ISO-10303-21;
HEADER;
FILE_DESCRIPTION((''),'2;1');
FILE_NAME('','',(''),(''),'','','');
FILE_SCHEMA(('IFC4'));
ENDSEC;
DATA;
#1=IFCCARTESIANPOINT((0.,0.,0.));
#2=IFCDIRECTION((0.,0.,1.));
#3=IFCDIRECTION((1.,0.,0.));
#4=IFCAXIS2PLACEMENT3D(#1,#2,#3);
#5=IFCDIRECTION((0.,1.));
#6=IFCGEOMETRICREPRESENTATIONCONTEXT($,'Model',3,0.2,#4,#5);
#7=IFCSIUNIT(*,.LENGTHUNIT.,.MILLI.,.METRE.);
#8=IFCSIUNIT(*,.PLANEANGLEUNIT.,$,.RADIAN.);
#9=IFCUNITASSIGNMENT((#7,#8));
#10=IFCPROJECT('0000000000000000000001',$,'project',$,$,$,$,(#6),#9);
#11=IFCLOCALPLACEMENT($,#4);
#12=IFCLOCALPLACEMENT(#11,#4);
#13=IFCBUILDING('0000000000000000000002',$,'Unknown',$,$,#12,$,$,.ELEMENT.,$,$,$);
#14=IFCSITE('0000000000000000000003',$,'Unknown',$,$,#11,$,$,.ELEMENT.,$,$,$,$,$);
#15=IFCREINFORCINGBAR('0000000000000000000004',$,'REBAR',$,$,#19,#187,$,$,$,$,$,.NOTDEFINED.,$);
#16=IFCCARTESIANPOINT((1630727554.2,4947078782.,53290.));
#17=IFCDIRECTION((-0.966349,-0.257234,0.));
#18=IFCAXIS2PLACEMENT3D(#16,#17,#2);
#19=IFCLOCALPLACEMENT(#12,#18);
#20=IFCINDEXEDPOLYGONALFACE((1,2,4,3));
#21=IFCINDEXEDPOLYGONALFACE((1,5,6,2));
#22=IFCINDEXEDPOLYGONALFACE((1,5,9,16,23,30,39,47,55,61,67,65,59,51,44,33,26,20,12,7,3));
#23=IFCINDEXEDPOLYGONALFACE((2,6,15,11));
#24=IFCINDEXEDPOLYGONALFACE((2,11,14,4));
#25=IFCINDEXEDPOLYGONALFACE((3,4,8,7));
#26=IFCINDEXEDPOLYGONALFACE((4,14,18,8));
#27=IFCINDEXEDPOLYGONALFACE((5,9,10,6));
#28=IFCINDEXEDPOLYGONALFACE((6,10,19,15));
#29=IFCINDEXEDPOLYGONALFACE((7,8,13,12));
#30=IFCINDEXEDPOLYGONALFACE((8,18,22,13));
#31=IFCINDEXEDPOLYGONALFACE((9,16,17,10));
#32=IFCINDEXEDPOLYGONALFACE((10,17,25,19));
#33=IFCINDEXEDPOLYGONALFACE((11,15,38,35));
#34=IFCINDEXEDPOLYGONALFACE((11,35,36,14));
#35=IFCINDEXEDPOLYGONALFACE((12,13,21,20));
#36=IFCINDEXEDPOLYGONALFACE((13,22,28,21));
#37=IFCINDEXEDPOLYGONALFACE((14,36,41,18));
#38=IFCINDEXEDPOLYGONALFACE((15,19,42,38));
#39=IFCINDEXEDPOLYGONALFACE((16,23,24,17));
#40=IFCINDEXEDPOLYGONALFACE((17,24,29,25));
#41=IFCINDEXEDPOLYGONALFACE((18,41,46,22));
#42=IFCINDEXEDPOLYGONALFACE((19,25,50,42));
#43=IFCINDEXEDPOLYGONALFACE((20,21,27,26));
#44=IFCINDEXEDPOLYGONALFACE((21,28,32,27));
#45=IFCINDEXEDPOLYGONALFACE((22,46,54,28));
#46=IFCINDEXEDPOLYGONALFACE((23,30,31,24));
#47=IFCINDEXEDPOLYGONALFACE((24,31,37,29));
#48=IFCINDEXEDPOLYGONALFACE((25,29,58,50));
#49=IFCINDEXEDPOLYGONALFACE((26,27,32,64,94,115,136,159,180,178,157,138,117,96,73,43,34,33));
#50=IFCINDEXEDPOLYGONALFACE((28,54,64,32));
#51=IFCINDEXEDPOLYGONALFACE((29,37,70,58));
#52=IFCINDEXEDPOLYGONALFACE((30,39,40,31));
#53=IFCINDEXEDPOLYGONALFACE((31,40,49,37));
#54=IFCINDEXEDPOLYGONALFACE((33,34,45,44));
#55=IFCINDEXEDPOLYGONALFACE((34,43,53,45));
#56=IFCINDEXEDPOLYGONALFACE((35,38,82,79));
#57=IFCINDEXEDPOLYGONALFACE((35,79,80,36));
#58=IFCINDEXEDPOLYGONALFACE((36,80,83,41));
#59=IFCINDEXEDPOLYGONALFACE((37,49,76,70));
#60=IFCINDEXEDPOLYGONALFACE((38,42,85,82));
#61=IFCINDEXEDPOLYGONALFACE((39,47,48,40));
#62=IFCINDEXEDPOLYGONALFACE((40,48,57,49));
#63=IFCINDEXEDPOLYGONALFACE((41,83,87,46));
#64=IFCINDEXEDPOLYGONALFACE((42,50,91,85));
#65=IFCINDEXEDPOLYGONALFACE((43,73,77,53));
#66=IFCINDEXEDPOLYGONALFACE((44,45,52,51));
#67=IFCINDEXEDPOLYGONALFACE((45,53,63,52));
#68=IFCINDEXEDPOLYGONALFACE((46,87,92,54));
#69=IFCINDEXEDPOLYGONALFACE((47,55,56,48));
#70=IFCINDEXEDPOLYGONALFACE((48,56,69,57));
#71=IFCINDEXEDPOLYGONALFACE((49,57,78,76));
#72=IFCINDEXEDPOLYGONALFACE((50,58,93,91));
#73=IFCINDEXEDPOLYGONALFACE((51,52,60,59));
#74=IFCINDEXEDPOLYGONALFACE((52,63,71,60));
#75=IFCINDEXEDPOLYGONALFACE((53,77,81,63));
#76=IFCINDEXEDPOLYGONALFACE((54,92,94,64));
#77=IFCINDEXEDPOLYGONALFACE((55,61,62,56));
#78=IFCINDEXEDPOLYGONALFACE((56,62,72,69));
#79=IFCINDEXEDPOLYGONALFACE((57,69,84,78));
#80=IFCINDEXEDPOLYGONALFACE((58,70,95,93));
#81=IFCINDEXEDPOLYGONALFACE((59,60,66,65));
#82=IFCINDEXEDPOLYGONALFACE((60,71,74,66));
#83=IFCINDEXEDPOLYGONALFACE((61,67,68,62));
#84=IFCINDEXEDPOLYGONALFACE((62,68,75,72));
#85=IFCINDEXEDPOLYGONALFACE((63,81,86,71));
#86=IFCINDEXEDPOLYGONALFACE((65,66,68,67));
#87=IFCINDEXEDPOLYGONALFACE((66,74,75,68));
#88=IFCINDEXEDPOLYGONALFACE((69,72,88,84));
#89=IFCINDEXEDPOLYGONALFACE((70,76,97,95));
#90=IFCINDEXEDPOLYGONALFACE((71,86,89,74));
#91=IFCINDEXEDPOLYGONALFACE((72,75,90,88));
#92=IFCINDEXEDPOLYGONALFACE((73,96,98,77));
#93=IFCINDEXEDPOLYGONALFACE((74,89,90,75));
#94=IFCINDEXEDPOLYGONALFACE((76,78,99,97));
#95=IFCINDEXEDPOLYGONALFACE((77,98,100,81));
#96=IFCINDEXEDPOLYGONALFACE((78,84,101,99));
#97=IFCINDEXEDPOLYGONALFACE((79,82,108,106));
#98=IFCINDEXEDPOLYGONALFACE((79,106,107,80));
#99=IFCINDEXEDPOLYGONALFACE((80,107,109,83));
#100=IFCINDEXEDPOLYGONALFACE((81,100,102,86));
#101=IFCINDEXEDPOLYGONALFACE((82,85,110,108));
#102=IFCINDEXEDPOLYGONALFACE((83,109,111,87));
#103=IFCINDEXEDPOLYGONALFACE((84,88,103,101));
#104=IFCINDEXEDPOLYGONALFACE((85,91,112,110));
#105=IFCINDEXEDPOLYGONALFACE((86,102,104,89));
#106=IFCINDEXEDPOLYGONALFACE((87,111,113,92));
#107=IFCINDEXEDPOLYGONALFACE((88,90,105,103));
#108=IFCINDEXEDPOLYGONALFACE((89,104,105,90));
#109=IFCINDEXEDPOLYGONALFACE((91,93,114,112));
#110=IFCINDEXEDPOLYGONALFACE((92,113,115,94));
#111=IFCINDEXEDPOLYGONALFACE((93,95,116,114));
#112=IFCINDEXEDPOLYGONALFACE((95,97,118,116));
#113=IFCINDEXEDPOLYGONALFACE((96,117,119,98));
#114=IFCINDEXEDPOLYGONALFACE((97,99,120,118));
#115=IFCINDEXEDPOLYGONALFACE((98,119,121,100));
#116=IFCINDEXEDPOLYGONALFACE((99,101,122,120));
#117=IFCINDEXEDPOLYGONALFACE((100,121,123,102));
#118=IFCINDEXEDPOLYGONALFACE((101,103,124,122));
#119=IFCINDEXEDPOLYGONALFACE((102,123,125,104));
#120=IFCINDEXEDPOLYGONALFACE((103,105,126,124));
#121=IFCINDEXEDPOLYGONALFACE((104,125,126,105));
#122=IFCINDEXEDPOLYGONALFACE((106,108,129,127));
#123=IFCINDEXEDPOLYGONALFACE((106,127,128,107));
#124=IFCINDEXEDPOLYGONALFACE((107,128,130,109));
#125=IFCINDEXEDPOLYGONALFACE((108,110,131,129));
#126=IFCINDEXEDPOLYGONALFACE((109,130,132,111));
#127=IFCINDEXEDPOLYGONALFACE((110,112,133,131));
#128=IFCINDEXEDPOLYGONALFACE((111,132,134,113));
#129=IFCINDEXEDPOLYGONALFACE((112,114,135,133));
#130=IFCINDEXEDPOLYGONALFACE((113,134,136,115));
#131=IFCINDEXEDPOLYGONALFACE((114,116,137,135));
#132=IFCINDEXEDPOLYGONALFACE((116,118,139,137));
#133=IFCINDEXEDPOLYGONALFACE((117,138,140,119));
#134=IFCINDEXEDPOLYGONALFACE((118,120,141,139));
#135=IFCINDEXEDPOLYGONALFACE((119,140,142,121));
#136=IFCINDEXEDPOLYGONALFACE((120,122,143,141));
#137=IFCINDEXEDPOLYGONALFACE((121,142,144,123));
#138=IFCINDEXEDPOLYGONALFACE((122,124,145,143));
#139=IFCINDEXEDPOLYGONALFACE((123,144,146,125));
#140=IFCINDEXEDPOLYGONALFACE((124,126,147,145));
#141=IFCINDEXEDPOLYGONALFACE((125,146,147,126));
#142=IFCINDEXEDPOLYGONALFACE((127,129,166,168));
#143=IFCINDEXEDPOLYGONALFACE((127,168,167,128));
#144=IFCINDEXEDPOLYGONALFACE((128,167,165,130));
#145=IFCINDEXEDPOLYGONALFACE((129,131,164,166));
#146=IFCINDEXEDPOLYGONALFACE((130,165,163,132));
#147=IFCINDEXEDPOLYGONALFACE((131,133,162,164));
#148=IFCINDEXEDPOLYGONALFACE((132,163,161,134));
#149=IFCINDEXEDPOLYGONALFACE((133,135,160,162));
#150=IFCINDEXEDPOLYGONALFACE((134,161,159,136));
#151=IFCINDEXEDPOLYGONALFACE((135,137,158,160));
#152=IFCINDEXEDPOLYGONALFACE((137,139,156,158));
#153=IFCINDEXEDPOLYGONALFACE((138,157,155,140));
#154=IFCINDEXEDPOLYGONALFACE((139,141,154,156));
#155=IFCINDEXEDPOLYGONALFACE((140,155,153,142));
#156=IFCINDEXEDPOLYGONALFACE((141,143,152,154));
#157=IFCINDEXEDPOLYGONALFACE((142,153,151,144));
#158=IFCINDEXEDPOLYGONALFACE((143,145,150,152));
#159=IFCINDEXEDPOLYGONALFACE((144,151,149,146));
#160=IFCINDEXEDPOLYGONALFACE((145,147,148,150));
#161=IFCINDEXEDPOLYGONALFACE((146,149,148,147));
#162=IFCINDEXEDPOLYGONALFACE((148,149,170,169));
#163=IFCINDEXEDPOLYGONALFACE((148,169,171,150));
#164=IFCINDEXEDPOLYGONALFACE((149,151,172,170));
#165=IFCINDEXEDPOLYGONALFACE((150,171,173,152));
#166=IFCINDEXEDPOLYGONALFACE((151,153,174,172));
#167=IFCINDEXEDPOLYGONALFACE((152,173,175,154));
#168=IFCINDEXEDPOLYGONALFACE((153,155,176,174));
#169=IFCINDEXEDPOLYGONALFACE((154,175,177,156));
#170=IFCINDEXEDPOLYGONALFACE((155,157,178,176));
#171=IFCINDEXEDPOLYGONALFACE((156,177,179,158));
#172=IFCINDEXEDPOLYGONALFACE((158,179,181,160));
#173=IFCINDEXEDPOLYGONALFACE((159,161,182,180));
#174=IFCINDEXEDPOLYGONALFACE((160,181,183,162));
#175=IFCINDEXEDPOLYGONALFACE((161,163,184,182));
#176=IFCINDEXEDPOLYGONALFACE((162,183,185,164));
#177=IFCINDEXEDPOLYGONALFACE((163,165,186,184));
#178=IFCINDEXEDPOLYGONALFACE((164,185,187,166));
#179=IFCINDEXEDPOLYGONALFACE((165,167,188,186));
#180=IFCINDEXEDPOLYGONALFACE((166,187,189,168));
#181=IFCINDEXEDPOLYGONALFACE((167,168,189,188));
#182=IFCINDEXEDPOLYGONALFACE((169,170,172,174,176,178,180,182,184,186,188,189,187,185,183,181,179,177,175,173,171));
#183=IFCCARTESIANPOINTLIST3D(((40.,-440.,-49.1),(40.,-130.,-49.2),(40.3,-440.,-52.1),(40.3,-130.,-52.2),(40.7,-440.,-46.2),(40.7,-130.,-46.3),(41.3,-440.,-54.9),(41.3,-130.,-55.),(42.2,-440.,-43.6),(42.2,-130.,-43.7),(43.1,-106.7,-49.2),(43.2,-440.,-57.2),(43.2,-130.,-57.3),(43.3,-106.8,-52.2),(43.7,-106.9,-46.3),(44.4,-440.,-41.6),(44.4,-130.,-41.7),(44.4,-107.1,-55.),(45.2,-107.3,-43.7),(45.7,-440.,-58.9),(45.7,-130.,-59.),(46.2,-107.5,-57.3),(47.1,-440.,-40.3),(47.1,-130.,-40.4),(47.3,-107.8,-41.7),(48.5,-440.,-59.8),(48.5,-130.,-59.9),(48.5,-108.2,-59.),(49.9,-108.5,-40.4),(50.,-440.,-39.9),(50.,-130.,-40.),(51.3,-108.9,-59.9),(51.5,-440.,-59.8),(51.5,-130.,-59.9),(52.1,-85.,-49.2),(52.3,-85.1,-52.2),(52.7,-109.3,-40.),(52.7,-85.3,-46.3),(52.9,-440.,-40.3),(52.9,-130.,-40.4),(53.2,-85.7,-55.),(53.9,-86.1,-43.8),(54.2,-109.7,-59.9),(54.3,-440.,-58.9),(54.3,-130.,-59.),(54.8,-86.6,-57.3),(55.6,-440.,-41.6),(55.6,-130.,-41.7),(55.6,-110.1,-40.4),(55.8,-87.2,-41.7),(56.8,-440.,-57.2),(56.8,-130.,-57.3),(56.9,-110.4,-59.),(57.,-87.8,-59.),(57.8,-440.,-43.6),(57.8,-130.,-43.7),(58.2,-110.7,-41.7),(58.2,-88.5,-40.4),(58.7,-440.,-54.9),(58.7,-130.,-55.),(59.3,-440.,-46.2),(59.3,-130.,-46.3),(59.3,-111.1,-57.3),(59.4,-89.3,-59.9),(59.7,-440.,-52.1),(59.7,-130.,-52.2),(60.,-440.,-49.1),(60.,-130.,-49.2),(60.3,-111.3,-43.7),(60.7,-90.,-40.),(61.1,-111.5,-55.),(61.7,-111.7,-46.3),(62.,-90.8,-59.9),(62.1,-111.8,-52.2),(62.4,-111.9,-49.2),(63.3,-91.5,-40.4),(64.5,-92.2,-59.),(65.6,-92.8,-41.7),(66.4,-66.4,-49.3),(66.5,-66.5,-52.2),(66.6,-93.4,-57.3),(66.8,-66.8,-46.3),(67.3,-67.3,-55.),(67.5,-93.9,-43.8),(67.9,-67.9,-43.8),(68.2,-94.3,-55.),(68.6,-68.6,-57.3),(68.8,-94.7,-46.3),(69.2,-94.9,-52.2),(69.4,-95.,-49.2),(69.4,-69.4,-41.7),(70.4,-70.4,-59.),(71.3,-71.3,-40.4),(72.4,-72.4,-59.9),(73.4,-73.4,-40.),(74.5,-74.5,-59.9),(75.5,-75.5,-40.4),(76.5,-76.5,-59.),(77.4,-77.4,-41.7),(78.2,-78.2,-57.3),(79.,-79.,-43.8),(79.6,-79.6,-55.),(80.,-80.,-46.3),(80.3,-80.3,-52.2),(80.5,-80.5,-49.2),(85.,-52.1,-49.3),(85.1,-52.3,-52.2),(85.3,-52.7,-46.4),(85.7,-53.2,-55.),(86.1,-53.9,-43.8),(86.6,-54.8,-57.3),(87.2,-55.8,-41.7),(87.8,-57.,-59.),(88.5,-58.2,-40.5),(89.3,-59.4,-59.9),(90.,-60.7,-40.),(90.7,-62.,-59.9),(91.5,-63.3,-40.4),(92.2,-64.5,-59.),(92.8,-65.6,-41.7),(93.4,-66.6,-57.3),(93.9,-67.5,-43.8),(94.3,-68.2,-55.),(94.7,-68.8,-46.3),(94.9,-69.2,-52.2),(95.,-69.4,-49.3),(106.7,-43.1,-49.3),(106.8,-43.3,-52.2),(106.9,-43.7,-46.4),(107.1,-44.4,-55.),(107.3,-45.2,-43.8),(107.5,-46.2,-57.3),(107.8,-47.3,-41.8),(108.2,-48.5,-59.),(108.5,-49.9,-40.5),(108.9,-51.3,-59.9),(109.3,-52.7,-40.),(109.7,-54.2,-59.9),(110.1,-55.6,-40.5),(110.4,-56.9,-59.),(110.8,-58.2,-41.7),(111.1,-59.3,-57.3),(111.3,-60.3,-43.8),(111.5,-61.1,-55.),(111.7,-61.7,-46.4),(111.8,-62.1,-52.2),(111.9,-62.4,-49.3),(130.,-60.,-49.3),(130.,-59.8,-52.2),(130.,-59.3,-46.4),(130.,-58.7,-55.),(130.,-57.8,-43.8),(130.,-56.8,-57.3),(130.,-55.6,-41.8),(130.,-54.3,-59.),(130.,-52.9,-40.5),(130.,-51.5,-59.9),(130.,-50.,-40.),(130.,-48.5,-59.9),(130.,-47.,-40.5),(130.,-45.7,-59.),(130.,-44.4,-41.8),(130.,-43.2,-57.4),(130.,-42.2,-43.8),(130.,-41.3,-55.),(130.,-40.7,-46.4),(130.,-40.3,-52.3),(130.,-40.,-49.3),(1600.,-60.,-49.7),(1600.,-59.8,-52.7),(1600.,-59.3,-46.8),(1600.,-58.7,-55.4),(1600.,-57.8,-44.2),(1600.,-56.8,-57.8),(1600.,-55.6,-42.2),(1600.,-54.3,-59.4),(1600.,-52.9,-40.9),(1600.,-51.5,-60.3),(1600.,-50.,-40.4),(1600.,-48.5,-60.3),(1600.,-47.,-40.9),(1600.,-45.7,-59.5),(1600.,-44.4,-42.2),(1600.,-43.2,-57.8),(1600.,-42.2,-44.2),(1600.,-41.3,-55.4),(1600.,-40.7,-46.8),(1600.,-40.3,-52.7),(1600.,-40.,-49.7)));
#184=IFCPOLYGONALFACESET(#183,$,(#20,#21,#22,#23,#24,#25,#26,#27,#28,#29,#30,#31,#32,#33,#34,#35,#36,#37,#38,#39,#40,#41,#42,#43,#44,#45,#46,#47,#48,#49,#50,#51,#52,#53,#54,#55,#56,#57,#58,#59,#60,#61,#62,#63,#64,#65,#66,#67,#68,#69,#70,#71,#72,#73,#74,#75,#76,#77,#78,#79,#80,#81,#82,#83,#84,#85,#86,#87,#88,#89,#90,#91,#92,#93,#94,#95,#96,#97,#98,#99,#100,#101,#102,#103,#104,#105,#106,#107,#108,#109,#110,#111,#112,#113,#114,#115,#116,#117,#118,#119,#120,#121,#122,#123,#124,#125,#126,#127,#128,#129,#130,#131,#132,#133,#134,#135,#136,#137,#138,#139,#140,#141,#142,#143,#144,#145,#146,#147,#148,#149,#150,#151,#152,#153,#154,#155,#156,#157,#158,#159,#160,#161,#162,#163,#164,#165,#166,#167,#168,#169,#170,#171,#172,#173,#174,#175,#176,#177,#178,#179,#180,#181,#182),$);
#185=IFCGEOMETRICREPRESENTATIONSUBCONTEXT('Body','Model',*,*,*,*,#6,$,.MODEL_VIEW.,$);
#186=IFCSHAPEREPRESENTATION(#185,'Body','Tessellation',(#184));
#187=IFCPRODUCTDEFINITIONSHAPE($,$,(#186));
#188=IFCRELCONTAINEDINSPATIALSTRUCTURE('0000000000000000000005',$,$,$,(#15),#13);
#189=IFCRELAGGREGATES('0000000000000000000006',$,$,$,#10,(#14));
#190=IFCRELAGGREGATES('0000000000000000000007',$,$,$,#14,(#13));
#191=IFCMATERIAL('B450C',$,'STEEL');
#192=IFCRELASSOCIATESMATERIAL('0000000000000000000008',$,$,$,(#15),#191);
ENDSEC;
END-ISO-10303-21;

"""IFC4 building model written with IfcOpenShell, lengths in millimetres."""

from ifc_helpers import new_model, entity, si_unit, direction, frame, origin_with_axes, place, context, subcontext, project, spatial, material, element, save


model = new_model("IFC4")

# Units and contexts
model_context = context("Model", 3, precision=0.2, world=origin_with_axes(), true_north=direction((0.0, 1.0)))
body_context = subcontext(model_context, "Body", "Model", "MODEL_VIEW")
ifc_project = project(units=[si_unit("LENGTHUNIT", "METRE", prefix="MILLI"), si_unit("PLANEANGLEUNIT", "RADIAN")], contexts=[model_context])

# Site, building
site_placement = place(None, origin_with_axes())
site = spatial("IfcSite", under=ifc_project, at=site_placement, Name="Unknown", CompositionType="ELEMENT")
building_placement = place(site_placement, origin_with_axes())
building = spatial("IfcBuilding", under=site, at=building_placement, Name="Unknown", CompositionType="ELEMENT")

# Reinforcing bar
ifc_material = material(Name="B450C", Category="STEEL")
reinforcing_bar_1_placement = place(building_placement, frame((1630727554.2, 4947078782.0, 53290.0), z_axis=(-0.966349, -0.257234, 0.0), x_axis=(0.0, 0.0, 1.0)))
element("IfcReinforcingBar", 1, at=reinforcing_bar_1_placement, inside=building, material=ifc_material, Name="REBAR", PredefinedType="NOTDEFINED", context=body_context, shape_type="AdvancedSweptSolid", body=[
    entity("IfcSweptDiskSolid", entity("IfcIndexedPolyCurve", entity("IfcCartesianPointList3D", [[50.0, -440.0, -49.9], [50.0, -130.0, -50.0], [73.4, -73.4, -50.0], [130.0, -50.0, -50.0], [1600.0, -50.0, -50.4]]), [entity("IfcLineIndex", [1, 2]), entity("IfcArcIndex", [2, 3, 4]), entity("IfcLineIndex", [4, 5])]), 10.0),
])

save(model, "model.ifc")
